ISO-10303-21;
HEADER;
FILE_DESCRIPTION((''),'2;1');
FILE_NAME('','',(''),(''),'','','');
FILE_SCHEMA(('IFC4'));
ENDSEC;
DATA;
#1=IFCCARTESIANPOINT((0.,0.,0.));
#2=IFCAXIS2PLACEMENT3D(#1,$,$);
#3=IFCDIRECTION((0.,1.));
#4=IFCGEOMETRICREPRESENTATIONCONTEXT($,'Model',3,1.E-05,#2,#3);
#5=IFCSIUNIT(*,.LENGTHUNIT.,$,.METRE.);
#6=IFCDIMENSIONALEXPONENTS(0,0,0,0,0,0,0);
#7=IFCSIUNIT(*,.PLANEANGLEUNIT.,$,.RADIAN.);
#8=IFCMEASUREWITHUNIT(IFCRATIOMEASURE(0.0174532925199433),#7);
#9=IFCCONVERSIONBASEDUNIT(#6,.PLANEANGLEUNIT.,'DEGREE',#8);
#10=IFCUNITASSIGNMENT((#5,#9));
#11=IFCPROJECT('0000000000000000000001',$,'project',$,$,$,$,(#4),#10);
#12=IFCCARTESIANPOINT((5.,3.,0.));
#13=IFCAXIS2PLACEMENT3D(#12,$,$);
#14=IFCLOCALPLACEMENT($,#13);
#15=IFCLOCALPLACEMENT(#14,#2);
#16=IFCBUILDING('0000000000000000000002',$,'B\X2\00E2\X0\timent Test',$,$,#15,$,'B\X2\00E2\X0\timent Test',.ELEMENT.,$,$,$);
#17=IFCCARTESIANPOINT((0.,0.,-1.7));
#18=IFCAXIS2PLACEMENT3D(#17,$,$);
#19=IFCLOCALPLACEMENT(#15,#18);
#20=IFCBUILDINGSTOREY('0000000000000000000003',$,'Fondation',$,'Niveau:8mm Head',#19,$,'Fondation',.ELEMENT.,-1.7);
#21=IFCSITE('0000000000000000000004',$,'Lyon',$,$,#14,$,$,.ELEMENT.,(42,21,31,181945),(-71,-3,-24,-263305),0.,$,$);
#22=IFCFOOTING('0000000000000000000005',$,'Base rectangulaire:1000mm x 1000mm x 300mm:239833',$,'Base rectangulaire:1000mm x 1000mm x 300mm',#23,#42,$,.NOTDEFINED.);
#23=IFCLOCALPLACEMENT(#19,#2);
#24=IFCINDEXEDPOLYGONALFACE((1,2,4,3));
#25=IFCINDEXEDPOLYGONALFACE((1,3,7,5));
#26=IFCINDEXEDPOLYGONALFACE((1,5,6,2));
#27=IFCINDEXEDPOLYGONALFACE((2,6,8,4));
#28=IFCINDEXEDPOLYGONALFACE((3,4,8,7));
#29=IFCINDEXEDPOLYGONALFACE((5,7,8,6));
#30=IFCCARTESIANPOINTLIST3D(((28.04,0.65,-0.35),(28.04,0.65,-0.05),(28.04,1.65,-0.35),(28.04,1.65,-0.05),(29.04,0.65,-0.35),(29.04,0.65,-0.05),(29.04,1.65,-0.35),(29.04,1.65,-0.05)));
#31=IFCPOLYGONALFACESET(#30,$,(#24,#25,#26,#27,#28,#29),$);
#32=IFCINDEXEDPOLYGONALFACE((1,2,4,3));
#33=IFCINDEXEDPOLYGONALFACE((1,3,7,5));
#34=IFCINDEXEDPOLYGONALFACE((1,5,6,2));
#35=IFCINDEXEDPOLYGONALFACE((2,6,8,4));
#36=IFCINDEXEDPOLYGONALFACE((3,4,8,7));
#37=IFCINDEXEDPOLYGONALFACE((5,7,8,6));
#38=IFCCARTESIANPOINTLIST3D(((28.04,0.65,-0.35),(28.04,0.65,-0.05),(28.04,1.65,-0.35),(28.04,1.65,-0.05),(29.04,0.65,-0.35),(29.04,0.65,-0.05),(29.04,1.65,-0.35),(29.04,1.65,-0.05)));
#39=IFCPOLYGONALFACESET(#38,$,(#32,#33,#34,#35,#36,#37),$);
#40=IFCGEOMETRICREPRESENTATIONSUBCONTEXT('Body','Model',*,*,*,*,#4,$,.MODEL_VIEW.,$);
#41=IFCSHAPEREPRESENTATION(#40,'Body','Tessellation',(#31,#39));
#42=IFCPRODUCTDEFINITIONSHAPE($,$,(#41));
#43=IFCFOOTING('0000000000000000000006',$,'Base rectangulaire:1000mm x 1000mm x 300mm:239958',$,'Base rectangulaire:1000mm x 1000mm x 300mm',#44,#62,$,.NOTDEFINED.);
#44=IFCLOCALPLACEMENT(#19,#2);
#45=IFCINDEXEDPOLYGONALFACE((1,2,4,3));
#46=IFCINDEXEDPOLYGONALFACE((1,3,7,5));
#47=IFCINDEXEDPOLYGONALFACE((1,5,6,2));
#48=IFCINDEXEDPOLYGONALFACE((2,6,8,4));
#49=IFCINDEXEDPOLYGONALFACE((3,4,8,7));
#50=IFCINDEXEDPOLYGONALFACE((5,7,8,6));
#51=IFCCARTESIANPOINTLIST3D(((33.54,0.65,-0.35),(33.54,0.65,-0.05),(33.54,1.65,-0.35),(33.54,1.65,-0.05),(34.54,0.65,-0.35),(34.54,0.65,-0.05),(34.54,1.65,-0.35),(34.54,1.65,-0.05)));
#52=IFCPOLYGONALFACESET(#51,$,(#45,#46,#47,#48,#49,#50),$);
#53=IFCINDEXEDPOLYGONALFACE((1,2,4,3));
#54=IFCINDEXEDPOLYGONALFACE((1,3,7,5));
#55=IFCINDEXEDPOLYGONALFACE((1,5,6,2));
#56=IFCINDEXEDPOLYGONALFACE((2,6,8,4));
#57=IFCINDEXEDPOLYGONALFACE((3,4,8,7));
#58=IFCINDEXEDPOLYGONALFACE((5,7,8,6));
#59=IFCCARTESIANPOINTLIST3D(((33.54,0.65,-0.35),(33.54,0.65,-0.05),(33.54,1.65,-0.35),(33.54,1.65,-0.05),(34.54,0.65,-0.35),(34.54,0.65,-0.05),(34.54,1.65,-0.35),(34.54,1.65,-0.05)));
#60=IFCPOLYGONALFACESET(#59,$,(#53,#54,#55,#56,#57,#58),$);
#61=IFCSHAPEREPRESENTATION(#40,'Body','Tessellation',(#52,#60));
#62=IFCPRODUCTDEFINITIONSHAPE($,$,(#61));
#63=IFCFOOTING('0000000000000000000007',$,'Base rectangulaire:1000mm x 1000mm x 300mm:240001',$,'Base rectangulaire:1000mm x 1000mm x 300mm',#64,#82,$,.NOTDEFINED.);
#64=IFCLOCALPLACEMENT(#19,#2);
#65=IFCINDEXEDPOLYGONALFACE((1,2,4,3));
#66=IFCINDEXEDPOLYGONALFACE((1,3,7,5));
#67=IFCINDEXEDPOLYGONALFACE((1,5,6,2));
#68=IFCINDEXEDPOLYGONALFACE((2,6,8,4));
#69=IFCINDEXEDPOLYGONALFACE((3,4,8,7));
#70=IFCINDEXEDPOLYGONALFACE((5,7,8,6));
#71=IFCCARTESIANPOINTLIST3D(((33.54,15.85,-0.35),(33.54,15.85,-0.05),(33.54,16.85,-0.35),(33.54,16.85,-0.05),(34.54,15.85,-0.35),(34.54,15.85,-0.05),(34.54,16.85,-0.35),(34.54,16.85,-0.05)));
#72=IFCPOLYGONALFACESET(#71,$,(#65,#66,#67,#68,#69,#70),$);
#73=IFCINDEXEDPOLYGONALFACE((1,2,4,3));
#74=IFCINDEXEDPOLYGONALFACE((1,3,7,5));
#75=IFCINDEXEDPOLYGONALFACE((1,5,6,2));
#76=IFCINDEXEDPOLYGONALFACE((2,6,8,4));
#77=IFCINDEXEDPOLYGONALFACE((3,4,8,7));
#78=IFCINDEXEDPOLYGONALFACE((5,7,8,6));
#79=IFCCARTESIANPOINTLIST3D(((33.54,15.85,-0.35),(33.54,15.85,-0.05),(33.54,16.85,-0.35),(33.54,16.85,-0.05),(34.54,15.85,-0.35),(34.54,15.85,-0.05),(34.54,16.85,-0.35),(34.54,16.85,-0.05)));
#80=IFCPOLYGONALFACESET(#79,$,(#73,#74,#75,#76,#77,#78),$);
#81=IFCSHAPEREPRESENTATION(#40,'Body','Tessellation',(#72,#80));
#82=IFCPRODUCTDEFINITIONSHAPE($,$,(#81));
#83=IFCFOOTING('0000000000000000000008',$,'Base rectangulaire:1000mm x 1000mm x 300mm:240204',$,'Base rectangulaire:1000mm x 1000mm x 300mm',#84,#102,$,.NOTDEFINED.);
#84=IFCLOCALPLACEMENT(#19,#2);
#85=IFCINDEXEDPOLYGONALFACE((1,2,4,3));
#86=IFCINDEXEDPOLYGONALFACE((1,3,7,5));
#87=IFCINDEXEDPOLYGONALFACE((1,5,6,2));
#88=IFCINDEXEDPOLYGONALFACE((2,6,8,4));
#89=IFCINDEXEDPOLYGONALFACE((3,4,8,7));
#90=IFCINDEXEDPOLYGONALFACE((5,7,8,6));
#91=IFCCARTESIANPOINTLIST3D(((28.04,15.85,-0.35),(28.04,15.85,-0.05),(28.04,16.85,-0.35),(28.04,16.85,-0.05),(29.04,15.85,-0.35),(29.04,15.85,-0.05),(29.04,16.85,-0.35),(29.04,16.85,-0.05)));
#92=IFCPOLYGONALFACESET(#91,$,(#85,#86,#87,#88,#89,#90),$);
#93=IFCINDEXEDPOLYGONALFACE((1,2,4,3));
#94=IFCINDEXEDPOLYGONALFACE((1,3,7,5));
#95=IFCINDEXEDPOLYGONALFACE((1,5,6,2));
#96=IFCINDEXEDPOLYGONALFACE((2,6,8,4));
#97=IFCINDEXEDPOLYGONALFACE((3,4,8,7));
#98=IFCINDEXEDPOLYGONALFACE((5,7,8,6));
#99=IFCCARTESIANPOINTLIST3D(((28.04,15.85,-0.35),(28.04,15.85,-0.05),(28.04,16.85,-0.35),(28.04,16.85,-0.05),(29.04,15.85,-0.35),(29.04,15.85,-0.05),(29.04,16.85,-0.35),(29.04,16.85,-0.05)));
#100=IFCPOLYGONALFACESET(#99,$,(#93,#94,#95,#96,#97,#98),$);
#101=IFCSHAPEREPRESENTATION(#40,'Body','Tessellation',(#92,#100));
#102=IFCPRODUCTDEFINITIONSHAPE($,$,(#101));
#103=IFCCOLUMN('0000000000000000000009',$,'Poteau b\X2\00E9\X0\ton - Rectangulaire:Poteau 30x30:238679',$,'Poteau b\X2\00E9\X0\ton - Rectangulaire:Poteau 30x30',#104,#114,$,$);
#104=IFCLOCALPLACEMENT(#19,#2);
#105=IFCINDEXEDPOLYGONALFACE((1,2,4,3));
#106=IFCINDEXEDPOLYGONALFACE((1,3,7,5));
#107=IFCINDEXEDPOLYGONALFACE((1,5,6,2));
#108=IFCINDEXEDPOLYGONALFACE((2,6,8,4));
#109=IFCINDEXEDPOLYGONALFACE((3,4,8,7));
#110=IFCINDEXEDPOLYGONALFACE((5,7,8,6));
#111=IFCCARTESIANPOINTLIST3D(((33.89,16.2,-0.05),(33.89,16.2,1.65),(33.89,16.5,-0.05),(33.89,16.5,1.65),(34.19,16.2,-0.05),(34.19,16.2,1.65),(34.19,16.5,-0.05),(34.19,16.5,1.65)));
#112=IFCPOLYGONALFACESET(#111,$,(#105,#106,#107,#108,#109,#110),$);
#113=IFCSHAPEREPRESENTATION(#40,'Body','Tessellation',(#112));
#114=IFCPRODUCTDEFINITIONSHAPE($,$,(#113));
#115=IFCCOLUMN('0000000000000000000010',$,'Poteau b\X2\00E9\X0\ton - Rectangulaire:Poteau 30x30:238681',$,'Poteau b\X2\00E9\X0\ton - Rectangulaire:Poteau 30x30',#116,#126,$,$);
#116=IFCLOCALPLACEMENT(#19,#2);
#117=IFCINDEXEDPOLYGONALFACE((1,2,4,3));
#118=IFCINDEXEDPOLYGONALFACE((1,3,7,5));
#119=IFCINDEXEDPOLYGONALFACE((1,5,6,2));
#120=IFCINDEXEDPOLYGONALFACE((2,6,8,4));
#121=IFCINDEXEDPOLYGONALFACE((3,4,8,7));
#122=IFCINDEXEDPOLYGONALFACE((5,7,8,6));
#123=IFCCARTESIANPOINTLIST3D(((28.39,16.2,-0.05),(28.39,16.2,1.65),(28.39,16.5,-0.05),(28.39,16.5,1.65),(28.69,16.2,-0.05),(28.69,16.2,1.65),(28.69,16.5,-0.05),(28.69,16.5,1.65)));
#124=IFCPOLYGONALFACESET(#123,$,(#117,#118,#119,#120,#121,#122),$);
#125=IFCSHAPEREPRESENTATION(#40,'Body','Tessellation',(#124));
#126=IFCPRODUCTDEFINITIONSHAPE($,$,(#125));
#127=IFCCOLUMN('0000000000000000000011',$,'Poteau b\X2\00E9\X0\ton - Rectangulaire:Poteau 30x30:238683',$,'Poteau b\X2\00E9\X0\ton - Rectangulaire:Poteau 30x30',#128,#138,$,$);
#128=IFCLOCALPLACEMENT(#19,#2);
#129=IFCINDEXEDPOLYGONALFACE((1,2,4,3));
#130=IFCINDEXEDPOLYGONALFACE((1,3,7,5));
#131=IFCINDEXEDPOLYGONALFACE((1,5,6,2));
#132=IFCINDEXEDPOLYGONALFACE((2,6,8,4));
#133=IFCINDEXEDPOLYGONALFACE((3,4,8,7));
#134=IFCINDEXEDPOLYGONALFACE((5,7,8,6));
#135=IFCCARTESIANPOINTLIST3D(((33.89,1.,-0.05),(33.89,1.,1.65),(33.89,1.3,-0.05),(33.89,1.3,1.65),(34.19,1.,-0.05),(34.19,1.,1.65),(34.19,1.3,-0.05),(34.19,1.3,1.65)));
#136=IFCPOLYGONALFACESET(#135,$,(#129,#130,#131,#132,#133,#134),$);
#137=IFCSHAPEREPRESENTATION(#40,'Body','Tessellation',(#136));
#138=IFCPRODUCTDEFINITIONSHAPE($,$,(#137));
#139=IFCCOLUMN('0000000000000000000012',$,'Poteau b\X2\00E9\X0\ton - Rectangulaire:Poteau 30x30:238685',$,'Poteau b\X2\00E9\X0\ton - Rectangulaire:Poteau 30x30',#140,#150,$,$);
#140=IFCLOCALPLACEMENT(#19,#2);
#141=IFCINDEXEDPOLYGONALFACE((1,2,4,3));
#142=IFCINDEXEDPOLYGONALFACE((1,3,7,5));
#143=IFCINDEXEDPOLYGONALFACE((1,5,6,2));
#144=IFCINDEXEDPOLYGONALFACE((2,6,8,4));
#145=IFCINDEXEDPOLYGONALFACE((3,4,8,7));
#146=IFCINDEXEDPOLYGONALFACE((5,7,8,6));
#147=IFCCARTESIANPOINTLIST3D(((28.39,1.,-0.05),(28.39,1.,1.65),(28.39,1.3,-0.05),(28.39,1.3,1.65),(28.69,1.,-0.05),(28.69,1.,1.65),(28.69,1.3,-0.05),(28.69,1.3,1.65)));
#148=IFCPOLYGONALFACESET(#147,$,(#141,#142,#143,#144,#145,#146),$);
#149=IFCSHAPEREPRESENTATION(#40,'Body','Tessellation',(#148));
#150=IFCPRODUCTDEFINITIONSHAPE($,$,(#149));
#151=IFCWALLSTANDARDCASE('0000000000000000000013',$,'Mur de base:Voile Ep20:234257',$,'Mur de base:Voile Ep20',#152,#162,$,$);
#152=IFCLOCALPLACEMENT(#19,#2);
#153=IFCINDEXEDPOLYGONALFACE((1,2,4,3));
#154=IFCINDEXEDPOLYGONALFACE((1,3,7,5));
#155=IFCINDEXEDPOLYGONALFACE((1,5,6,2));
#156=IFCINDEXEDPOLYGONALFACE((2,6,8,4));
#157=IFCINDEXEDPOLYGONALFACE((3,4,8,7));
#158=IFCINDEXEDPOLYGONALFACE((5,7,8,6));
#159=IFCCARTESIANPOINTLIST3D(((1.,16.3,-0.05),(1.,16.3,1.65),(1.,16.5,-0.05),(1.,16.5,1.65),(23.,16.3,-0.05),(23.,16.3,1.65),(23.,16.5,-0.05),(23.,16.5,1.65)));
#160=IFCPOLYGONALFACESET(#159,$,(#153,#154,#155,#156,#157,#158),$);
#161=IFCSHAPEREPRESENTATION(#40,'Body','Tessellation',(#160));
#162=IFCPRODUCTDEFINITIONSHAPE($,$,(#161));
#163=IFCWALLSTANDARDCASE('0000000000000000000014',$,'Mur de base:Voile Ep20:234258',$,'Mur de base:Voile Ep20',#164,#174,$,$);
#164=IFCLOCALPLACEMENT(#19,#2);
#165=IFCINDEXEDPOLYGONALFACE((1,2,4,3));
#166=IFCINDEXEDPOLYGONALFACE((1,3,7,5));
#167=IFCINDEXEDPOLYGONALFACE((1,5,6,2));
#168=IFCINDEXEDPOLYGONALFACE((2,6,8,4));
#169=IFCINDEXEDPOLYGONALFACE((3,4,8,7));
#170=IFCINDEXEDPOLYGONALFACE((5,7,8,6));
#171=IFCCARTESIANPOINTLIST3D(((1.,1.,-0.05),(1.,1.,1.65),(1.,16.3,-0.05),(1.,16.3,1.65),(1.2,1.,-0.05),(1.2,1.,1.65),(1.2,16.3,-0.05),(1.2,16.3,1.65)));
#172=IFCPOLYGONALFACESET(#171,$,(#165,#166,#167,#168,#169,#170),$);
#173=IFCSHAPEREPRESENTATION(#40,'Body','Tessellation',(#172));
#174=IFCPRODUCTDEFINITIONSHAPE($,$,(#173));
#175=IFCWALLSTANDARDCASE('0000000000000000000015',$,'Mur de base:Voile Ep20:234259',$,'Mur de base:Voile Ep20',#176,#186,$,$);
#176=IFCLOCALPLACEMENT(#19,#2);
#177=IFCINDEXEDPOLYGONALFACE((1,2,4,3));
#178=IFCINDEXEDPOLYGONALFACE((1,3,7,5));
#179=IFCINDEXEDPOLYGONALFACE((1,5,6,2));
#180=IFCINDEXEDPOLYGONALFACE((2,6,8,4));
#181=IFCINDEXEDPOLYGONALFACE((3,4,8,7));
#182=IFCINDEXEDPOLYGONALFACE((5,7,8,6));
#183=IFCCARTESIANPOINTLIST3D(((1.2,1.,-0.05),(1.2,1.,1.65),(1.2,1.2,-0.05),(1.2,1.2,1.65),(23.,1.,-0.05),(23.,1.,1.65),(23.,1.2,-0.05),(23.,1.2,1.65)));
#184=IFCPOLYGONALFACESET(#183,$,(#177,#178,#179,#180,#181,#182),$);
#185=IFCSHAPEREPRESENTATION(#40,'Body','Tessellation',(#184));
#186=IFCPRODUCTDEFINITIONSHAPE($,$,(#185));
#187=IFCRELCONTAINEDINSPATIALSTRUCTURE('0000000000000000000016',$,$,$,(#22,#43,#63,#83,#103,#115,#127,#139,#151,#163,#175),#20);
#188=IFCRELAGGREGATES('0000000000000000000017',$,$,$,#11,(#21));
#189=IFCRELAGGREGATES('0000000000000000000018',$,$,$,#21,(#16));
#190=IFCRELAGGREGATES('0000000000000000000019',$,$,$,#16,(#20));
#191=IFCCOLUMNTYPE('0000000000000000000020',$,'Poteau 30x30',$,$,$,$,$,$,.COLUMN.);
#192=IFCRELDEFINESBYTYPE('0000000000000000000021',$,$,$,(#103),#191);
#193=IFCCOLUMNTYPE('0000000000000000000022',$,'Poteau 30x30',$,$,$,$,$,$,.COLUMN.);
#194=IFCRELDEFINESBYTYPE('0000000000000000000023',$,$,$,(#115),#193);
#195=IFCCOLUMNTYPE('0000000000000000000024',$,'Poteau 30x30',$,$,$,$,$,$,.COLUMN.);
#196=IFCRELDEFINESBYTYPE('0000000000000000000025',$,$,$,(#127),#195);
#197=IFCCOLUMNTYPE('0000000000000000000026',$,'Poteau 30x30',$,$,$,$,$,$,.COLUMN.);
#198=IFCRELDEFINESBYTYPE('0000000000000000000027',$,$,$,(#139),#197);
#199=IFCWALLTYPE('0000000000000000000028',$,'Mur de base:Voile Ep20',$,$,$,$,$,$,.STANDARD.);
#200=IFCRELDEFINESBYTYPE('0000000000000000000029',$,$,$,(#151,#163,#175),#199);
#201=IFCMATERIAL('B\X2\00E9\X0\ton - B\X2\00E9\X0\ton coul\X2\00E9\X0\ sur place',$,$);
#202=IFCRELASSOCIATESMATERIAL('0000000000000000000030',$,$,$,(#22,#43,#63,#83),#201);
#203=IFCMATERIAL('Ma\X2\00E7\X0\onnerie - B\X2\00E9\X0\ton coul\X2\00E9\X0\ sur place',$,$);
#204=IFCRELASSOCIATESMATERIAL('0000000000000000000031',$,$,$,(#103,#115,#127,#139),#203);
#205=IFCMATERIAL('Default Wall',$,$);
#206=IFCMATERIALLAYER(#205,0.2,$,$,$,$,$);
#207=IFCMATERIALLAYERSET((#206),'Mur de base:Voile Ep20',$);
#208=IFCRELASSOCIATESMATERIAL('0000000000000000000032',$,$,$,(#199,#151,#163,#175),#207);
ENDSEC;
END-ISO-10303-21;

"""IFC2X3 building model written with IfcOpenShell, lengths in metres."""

from ifc_helpers import new_model, entity, si_unit, converted_unit, direction, frame, frame_2d, origin, origin_2d_with_axis, place, context, subcontext, project, spatial, rectangle, extrude, source, transform, mapped, material, layer, layer_set, layer_usage, type_object, type_shapes, element, save


model = new_model("IFC2X3")

# Units and contexts
model_context = context("Model", 3, precision=1e-05, world=origin(), true_north=direction((0.0, 1.0)))
body_context = subcontext(model_context, "Body", "Model", "MODEL_VIEW")
ifc_project = project(units=[si_unit("LENGTHUNIT", "METRE"), converted_unit("PLANEANGLEUNIT", "DEGREE", entity("IfcRatioMeasure", 0.0174532925199433), si_unit("PLANEANGLEUNIT", "RADIAN"), dimensions=[0, 0, 0, 0, 0, 0, 0])], contexts=[model_context])

# Site, building, storey
site_placement = place(None, frame((5.0, 3.0, 0.0)))
site = spatial("IfcSite", under=ifc_project, at=site_placement, Name="Lyon", CompositionType="ELEMENT", RefLatitude=(42, 21, 31, 181945), RefLongitude=(-71, -3, -24, -263305), RefElevation=0.0)
building_placement = place(site_placement, origin())
building = spatial("IfcBuilding", under=site, at=building_placement, Name="Bâtiment Test", LongName="Bâtiment Test", CompositionType="ELEMENT")
storey_placement = place(building_placement, frame((0.0, 0.0, -1.7)))
storey = spatial("IfcBuildingStorey", under=building, at=storey_placement, Name="Fondation", ObjectType="Niveau:8mm Head", LongName="Fondation", CompositionType="ELEMENT", Elevation=-1.7)

# Footings
ifc_material_1 = material(Name="Béton - Béton coulé sur place")
footing_1_placement = place(storey_placement, origin())
element("IfcFooting", 1, at=footing_1_placement, inside=storey, material=ifc_material_1, Name="Base rectangulaire:1000mm x 1000mm x 300mm:239833", ObjectType="Base rectangulaire:1000mm x 1000mm x 300mm", PredefinedType="NOTDEFINED", context=body_context, shape_type="SweptSolid", body=[
    extrude(rectangle(XDim=1.0, YDim=1.0, at=frame_2d((0.0, 0.0), x_axis=(1.0, 0.0))), frame((28.54, 1.15, -0.35), z_axis=(0.0, 0.0, 1.0), x_axis=(-1.0, 0.0, 0.0)), (0.0, 0.0, 1.0), 0.3),
    extrude(rectangle(XDim=1.0, YDim=1.0, at=frame_2d((0.0, 0.0), x_axis=(1.0, 0.0))), frame((28.54, 1.15, -0.35), z_axis=(0.0, 0.0, 1.0), x_axis=(-1.0, 0.0, 0.0)), (0.0, 0.0, 1.0), 0.3),
])
footing_2_placement = place(storey_placement, origin())
element("IfcFooting", 2, at=footing_2_placement, inside=storey, material=ifc_material_1, Name="Base rectangulaire:1000mm x 1000mm x 300mm:239958", ObjectType="Base rectangulaire:1000mm x 1000mm x 300mm", PredefinedType="NOTDEFINED", context=body_context, shape_type="SweptSolid", body=[
    extrude(rectangle(XDim=1.0, YDim=1.0, at=frame_2d((0.0, 0.0), x_axis=(1.0, 0.0))), frame((34.04, 1.15, -0.35), z_axis=(0.0, 0.0, 1.0), x_axis=(-1.0, 0.0, 0.0)), (0.0, 0.0, 1.0), 0.3),
    extrude(rectangle(XDim=1.0, YDim=1.0, at=frame_2d((0.0, 0.0), x_axis=(1.0, 0.0))), frame((34.04, 1.15, -0.35), z_axis=(0.0, 0.0, 1.0), x_axis=(-1.0, 0.0, 0.0)), (0.0, 0.0, 1.0), 0.3),
])
footing_3_placement = place(storey_placement, origin())
element("IfcFooting", 3, at=footing_3_placement, inside=storey, material=ifc_material_1, Name="Base rectangulaire:1000mm x 1000mm x 300mm:240001", ObjectType="Base rectangulaire:1000mm x 1000mm x 300mm", PredefinedType="NOTDEFINED", context=body_context, shape_type="SweptSolid", body=[
    extrude(rectangle(XDim=1.0, YDim=1.0, at=frame_2d((0.0, 0.0), x_axis=(1.0, 0.0))), frame((34.04, 16.35, -0.35), z_axis=(0.0, 0.0, 1.0), x_axis=(-1.0, 0.0, 0.0)), (0.0, 0.0, 1.0), 0.3),
    extrude(rectangle(XDim=1.0, YDim=1.0, at=frame_2d((0.0, 0.0), x_axis=(1.0, 0.0))), frame((34.04, 16.35, -0.35), z_axis=(0.0, 0.0, 1.0), x_axis=(-1.0, 0.0, 0.0)), (0.0, 0.0, 1.0), 0.3),
])
footing_4_placement = place(storey_placement, origin())
element("IfcFooting", 4, at=footing_4_placement, inside=storey, material=ifc_material_1, Name="Base rectangulaire:1000mm x 1000mm x 300mm:240204", ObjectType="Base rectangulaire:1000mm x 1000mm x 300mm", PredefinedType="NOTDEFINED", context=body_context, shape_type="SweptSolid", body=[
    extrude(rectangle(XDim=1.0, YDim=1.0, at=frame_2d((0.0, 0.0), x_axis=(1.0, 0.0))), frame((28.54, 16.35, -0.35), z_axis=(0.0, 0.0, 1.0), x_axis=(-1.0, 0.0, 0.0)), (0.0, 0.0, 1.0), 0.3),
    extrude(rectangle(XDim=1.0, YDim=1.0, at=frame_2d((0.0, 0.0), x_axis=(1.0, 0.0))), frame((28.54, 16.35, -0.35), z_axis=(0.0, 0.0, 1.0), x_axis=(-1.0, 0.0, 0.0)), (0.0, 0.0, 1.0), 0.3),
])

# Columns
ifc_material_2 = material(Name="Maçonnerie - Béton coulé sur place")
column_type_1 = type_object("IfcColumnType", Name="Poteau 30x30", PredefinedType="COLUMN")
shared_shape_1 = source(origin(), body_context, "Body", "SweptSolid", [
    extrude(rectangle(XDim=0.3, YDim=0.3, at=origin_2d_with_axis()), frame((34.04, 16.35, -1.75), z_axis=(0.0, 0.0, 1.0), x_axis=(0.0, -1.0, 0.0)), (0.0, 0.0, 1.0), 1.7),
])
type_shapes(column_type_1, [shared_shape_1])
column_1_placement = place(storey_placement, frame((0.0, 0.0, 1.7)))
element("IfcColumn", 5, at=column_1_placement, inside=storey, type_object=column_type_1, material=ifc_material_2, Name="Poteau béton - Rectangulaire:Poteau 30x30:238679", ObjectType="Poteau béton - Rectangulaire:Poteau 30x30", context=body_context, shape_type="MappedRepresentation", body=[
    mapped(shared_shape_1, transform((0.0, 0.0, 0.0), scale=1.0)),
])
column_type_2 = type_object("IfcColumnType", Name="Poteau 30x30", PredefinedType="COLUMN")
shared_shape_2 = source(origin(), body_context, "Body", "SweptSolid", [
    extrude(rectangle(XDim=0.3, YDim=0.3, at=origin_2d_with_axis()), frame((28.54, 16.35, -1.75), z_axis=(0.0, 0.0, 1.0), x_axis=(0.0, -1.0, 0.0)), (0.0, 0.0, 1.0), 1.7),
])
type_shapes(column_type_2, [shared_shape_2])
column_2_placement = place(storey_placement, frame((0.0, 0.0, 1.7)))
element("IfcColumn", 6, at=column_2_placement, inside=storey, type_object=column_type_2, material=ifc_material_2, Name="Poteau béton - Rectangulaire:Poteau 30x30:238681", ObjectType="Poteau béton - Rectangulaire:Poteau 30x30", context=body_context, shape_type="MappedRepresentation", body=[
    mapped(shared_shape_2, transform((0.0, 0.0, 0.0), scale=1.0)),
])
column_type_3 = type_object("IfcColumnType", Name="Poteau 30x30", PredefinedType="COLUMN")
shared_shape_3 = source(origin(), body_context, "Body", "SweptSolid", [
    extrude(rectangle(XDim=0.3, YDim=0.3, at=frame_2d((0.0, 0.0), x_axis=(1.0, 0.0))), frame((34.04, 1.15, -1.75), z_axis=(0.0, 0.0, 1.0), x_axis=(0.0, -1.0, 0.0)), (0.0, 0.0, 1.0), 1.7),
])
type_shapes(column_type_3, [shared_shape_3])
column_3_placement = place(storey_placement, frame((0.0, 0.0, 1.7)))
element("IfcColumn", 7, at=column_3_placement, inside=storey, type_object=column_type_3, material=ifc_material_2, Name="Poteau béton - Rectangulaire:Poteau 30x30:238683", ObjectType="Poteau béton - Rectangulaire:Poteau 30x30", context=body_context, shape_type="MappedRepresentation", body=[
    mapped(shared_shape_3, transform((0.0, 0.0, 0.0), scale=1.0)),
])
column_type_4 = type_object("IfcColumnType", Name="Poteau 30x30", PredefinedType="COLUMN")
shared_shape_4 = source(origin(), body_context, "Body", "SweptSolid", [
    extrude(rectangle(XDim=0.3, YDim=0.3, at=frame_2d((0.0, 0.0), x_axis=(1.0, 0.0))), frame((28.54, 1.15, -1.75), z_axis=(0.0, 0.0, 1.0), x_axis=(0.0, -1.0, 0.0)), (0.0, 0.0, 1.0), 1.7),
])
type_shapes(column_type_4, [shared_shape_4])
column_4_placement = place(storey_placement, frame((0.0, 0.0, 1.7)))
element("IfcColumn", 8, at=column_4_placement, inside=storey, type_object=column_type_4, material=ifc_material_2, Name="Poteau béton - Rectangulaire:Poteau 30x30:238685", ObjectType="Poteau béton - Rectangulaire:Poteau 30x30", context=body_context, shape_type="MappedRepresentation", body=[
    mapped(shared_shape_4, transform((0.0, 0.0, 0.0), scale=1.0)),
])

# Walls
ifc_material_3 = material(Name="Default Wall")
ifc_layer_1 = layer(ifc_material_3, 0.2)
ifc_layer_set_1 = layer_set([ifc_layer_1], Name="Mur de base:Voile Ep20")
ifc_layer_usage_1 = layer_usage(ifc_layer_set_1, "AXIS2", "POSITIVE", -0.1)
wall_type_1 = type_object("IfcWallType", Name="Mur de base:Voile Ep20", PredefinedType="STANDARD", material=ifc_layer_set_1)
wall_1_placement = place(storey_placement, frame((23.0, 16.4, -0.05), z_axis=(0.0, 0.0, 1.0), x_axis=(-1.0, 0.0, 0.0)))
element("IfcWallStandardCase", 9, at=wall_1_placement, inside=storey, type_object=wall_type_1, material=ifc_layer_usage_1, Name="Mur de base:Voile Ep20:234257", ObjectType="Mur de base:Voile Ep20", context=body_context, shape_type="SweptSolid", body=[
    extrude(rectangle(XDim=22.0, YDim=0.2, at=frame_2d((11.0, 0.0), x_axis=(-1.0, 0.0))), origin(), (0.0, 0.0, 1.0), 1.7),
])
ifc_layer_usage_2 = layer_usage(ifc_layer_set_1, "AXIS2", "POSITIVE", -0.1)
wall_2_placement = place(storey_placement, frame((1.1, 16.3, -0.05), z_axis=(0.0, 0.0, 1.0), x_axis=(0.0, -1.0, 0.0)))
element("IfcWallStandardCase", 10, at=wall_2_placement, inside=storey, type_object=wall_type_1, material=ifc_layer_usage_2, Name="Mur de base:Voile Ep20:234258", ObjectType="Mur de base:Voile Ep20", context=body_context, shape_type="SweptSolid", body=[
    extrude(rectangle(XDim=15.3, YDim=0.2, at=frame_2d((7.65, 0.0), x_axis=(-1.0, 0.0))), origin(), (0.0, 0.0, 1.0), 1.7),
])
ifc_layer_usage_3 = layer_usage(ifc_layer_set_1, "AXIS2", "POSITIVE", -0.1)
wall_3_placement = place(storey_placement, frame((1.2, 1.1, -0.05)))
element("IfcWallStandardCase", 11, at=wall_3_placement, inside=storey, type_object=wall_type_1, material=ifc_layer_usage_3, Name="Mur de base:Voile Ep20:234259", ObjectType="Mur de base:Voile Ep20", context=body_context, shape_type="SweptSolid", body=[
    extrude(rectangle(XDim=21.8, YDim=0.2, at=frame_2d((10.9, 0.0), x_axis=(-1.0, 0.0))), origin(), (0.0, 0.0, 1.0), 1.7),
])

save(model, "model.ifc")
